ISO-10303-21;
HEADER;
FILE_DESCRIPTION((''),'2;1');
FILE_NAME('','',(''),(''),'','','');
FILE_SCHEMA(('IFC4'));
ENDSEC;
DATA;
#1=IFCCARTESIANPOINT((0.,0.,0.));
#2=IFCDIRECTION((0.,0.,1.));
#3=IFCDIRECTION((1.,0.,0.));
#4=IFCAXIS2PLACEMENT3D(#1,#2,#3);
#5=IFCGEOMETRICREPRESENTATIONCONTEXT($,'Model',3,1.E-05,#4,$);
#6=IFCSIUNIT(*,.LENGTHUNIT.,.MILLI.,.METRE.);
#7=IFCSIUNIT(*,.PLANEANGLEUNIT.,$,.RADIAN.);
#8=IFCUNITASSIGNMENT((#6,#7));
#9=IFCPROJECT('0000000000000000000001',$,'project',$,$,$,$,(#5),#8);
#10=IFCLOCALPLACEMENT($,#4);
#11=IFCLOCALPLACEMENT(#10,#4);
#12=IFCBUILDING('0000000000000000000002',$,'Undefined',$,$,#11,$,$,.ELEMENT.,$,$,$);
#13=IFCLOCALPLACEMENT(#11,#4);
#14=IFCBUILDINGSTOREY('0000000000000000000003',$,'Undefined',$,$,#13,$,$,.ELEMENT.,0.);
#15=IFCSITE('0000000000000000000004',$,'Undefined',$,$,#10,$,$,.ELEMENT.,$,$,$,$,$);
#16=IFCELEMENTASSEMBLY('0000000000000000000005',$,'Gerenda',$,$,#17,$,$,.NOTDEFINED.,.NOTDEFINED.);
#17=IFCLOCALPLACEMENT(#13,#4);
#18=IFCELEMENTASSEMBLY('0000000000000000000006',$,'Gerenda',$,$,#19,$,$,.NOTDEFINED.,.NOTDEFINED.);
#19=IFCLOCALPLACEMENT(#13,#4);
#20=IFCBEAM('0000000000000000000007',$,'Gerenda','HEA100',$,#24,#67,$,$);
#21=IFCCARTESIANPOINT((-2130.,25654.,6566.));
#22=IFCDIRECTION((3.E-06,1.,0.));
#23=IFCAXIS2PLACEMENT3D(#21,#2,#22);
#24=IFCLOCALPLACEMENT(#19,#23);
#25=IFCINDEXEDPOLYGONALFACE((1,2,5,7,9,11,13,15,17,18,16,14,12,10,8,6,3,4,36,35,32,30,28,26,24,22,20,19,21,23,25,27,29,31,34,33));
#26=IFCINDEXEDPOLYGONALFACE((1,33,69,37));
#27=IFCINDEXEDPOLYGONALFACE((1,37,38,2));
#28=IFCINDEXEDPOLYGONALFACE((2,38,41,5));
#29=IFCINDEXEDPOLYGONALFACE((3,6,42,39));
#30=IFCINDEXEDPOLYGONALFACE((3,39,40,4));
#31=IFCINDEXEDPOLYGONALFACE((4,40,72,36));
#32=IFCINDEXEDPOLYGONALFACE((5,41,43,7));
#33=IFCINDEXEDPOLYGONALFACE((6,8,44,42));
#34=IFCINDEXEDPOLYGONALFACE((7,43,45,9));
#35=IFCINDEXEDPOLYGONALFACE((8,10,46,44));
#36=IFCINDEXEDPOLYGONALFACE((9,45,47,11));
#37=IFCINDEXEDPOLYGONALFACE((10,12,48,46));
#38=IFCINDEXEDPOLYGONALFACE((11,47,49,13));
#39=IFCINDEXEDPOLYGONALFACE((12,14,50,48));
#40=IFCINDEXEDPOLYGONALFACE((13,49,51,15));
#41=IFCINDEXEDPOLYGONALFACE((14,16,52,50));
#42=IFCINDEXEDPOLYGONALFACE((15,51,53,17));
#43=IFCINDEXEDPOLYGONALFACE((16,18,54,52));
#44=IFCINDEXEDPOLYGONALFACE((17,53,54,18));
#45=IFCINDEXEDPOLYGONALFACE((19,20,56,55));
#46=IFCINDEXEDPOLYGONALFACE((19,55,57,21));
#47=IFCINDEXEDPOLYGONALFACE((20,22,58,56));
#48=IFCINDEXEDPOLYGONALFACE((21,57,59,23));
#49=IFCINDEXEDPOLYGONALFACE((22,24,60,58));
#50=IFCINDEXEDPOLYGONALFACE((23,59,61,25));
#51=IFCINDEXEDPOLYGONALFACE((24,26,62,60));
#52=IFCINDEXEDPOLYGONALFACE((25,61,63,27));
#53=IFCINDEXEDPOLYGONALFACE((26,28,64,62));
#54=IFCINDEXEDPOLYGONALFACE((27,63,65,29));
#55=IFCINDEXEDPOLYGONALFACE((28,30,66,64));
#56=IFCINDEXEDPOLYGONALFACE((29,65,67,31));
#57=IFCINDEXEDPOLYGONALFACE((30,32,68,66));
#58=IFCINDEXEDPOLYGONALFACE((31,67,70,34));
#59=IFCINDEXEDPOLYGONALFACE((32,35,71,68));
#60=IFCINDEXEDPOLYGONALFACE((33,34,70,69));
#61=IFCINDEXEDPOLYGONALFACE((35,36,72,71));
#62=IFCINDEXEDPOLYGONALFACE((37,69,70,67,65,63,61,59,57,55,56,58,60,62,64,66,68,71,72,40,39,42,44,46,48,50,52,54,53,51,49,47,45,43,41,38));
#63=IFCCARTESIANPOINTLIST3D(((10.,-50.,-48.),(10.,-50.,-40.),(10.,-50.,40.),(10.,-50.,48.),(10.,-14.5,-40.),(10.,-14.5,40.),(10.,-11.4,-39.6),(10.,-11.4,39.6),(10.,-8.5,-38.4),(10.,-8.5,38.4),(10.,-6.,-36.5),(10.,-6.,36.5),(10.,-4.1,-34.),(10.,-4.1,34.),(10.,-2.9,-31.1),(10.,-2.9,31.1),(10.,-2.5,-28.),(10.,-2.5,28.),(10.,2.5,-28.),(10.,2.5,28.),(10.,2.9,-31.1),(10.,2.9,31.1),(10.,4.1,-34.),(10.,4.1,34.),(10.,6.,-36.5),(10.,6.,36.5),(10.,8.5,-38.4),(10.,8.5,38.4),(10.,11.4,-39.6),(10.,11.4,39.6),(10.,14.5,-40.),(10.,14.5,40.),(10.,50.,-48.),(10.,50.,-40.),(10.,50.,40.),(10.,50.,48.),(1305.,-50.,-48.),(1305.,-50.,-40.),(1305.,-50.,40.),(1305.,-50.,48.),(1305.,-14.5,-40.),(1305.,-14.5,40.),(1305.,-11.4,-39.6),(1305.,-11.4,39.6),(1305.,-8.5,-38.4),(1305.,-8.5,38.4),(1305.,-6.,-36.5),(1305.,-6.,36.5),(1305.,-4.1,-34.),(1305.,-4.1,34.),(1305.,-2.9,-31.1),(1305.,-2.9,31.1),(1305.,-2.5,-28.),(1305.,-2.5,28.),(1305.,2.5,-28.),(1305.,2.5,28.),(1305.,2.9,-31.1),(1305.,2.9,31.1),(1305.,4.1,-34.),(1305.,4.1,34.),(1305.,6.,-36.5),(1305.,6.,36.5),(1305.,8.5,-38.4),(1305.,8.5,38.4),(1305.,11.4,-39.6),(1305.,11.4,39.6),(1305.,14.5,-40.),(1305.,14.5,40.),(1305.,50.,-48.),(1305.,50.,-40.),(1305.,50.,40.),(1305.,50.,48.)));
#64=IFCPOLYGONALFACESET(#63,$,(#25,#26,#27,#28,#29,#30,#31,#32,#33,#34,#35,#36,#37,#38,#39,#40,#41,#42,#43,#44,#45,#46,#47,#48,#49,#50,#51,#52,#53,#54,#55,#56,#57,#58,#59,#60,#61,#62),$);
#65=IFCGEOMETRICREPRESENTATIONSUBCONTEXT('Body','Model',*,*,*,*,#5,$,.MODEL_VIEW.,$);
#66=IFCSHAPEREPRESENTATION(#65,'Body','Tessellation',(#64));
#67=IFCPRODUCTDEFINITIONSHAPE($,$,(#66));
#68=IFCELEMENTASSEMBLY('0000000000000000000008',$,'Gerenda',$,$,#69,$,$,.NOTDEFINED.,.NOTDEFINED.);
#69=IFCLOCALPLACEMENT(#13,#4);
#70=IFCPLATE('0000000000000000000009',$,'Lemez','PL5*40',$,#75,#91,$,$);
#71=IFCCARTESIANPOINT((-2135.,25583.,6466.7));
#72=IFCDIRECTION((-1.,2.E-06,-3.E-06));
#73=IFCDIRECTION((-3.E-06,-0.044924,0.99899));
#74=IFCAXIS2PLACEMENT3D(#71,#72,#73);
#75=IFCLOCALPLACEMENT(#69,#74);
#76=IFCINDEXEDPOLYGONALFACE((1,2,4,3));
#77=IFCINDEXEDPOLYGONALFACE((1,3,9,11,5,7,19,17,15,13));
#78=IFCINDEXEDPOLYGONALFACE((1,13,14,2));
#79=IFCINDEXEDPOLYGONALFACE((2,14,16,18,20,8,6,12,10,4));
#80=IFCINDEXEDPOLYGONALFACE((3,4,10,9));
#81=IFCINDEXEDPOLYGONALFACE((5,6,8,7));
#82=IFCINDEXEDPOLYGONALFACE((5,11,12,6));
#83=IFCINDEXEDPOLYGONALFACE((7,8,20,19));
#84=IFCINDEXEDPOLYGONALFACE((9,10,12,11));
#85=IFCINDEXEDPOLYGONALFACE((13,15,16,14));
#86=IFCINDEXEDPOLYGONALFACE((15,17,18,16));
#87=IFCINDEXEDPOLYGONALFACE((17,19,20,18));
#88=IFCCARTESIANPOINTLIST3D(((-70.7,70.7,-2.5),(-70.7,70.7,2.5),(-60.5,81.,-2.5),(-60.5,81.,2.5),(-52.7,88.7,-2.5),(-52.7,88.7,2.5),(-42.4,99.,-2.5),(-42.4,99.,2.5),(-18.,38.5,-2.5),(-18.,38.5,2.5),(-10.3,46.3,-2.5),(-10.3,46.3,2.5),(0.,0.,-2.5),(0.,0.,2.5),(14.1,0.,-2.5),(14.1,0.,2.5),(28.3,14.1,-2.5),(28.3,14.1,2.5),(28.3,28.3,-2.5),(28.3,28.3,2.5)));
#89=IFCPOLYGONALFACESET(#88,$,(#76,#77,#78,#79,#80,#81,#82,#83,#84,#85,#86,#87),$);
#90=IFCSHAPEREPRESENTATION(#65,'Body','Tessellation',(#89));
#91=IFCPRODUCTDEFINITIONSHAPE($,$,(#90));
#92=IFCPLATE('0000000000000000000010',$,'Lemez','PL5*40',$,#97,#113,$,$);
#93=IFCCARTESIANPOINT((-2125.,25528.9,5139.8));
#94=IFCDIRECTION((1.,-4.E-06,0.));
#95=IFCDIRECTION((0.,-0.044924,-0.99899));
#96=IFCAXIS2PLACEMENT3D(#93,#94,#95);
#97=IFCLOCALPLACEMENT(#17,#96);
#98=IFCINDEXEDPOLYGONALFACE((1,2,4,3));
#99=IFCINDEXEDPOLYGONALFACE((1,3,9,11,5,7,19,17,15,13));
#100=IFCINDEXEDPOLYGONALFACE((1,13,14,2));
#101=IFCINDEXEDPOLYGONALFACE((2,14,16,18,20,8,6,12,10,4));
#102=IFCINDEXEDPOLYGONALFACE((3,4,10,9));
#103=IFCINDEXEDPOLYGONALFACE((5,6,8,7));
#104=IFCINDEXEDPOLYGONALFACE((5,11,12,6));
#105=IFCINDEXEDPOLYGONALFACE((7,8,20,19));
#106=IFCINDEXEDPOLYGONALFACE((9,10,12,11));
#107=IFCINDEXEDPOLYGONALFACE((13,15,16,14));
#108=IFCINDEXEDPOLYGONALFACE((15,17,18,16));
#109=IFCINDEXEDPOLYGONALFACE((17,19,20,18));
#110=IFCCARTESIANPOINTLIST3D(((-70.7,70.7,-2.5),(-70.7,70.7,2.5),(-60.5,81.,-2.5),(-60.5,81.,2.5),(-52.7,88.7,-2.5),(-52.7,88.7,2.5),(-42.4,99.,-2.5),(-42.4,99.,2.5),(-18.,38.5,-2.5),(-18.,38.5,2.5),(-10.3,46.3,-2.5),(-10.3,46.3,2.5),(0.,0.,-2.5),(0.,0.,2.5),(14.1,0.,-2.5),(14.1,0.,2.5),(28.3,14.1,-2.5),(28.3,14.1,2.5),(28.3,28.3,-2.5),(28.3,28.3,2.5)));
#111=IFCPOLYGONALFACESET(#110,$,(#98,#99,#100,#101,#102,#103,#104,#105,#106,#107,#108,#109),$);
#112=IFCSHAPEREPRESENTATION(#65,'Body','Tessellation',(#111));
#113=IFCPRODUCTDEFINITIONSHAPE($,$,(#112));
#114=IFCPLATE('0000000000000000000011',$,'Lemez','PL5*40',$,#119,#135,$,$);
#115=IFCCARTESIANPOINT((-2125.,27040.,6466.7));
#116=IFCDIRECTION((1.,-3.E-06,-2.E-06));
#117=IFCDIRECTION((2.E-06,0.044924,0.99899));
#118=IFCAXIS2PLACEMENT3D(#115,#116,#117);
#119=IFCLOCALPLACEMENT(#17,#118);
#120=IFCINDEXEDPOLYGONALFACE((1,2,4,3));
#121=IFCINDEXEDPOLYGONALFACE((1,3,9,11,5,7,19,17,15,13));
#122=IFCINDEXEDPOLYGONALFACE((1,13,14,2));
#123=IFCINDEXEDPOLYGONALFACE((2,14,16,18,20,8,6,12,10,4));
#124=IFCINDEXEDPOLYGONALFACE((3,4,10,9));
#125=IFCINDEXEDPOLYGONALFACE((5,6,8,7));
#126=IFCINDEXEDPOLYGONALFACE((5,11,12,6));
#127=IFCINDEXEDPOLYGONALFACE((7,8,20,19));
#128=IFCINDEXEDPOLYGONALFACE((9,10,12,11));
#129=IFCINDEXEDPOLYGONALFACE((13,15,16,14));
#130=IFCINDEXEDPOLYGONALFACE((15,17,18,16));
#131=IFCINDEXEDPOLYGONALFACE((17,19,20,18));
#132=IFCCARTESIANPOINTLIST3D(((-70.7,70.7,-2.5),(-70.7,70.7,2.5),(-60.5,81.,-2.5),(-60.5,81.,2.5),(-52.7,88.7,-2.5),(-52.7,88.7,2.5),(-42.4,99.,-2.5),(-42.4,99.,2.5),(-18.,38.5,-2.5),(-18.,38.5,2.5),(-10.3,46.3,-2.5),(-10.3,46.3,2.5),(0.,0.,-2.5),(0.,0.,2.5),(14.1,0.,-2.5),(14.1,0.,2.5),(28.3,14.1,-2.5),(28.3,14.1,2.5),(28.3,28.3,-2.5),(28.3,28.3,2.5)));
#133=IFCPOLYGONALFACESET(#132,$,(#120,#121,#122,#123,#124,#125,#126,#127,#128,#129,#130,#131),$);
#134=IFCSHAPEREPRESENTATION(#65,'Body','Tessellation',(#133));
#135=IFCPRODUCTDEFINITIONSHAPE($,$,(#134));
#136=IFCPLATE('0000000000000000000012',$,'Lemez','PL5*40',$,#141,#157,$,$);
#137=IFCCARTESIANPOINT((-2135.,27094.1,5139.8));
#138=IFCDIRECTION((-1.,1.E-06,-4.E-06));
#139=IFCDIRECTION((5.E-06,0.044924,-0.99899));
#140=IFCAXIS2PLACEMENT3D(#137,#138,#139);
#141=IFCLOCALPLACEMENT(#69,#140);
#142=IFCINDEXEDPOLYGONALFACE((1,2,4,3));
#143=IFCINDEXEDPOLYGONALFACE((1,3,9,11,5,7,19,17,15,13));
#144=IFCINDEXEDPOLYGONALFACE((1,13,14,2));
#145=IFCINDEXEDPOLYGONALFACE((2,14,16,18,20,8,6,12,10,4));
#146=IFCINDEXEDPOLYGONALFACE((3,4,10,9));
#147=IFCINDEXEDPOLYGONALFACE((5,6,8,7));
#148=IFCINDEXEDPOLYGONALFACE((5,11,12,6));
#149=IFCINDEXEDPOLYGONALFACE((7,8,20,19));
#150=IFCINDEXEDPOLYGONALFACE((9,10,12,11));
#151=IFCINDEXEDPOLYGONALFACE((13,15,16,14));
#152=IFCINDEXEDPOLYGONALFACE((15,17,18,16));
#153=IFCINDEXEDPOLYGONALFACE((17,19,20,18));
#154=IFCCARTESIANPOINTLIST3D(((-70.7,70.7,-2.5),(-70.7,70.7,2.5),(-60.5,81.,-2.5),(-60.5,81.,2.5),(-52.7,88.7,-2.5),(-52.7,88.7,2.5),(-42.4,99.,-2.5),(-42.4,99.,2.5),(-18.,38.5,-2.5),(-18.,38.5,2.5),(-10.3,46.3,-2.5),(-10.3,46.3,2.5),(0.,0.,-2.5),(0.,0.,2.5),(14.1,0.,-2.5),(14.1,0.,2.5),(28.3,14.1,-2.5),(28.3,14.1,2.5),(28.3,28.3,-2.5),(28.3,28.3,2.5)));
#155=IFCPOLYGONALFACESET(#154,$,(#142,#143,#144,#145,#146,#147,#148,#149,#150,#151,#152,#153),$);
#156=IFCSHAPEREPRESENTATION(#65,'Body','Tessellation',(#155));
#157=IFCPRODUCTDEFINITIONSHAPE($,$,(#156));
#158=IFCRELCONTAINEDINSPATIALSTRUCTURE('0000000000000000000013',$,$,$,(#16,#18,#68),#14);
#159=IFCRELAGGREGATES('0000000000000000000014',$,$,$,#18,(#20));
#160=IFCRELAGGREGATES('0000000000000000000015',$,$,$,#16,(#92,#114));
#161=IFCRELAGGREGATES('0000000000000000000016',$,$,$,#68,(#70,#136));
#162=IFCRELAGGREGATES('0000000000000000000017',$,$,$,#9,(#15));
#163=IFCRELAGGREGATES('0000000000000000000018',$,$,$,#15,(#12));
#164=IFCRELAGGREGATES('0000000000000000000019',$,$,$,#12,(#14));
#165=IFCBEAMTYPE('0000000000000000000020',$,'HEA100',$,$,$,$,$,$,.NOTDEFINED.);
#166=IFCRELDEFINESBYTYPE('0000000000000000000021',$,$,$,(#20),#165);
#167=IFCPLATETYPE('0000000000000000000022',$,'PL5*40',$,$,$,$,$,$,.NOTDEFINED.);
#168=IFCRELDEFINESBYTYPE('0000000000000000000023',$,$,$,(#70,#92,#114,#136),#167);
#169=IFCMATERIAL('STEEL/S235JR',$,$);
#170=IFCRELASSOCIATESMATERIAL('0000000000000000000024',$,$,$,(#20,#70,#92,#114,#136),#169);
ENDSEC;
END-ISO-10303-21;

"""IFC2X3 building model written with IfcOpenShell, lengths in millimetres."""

from ifc_helpers import new_model, si_unit, frame, origin_with_axes, origin_2d_with_axis, place, context, subcontext, project, spatial, polyline, i_section, outline, extrude, clip, halfspace, material, type_object, element, aggregate, save


model = new_model("IFC2X3")

# Units and contexts
model_context = context("Model", 3, precision=1e-05, world=origin_with_axes())
body_context = subcontext(model_context, "Body", "Model", "MODEL_VIEW")
ifc_project = project(units=[si_unit("LENGTHUNIT", "METRE", prefix="MILLI"), si_unit("PLANEANGLEUNIT", "RADIAN")], contexts=[model_context])

# Site, building, storey
site_placement = place(None, origin_with_axes())
site = spatial("IfcSite", under=ifc_project, at=site_placement, Name="Undefined", CompositionType="ELEMENT")
building_placement = place(site_placement, origin_with_axes())
building = spatial("IfcBuilding", under=site, at=building_placement, Name="Undefined", CompositionType="ELEMENT")
storey_placement = place(building_placement, origin_with_axes())
storey = spatial("IfcBuildingStorey", under=building, at=storey_placement, Name="Undefined", CompositionType="ELEMENT", Elevation=0.0)

# Shared definitions
ifc_material_1 = material(Name="STEEL/S235JR")

# Element assemblies, beam
assembly_1_placement = place(storey_placement, origin_with_axes())
assembly_1 = element("IfcElementAssembly", 1, at=assembly_1_placement, inside=storey, Name="Gerenda", AssemblyPlace="NOTDEFINED", PredefinedType="NOTDEFINED")
assembly_2_placement = place(storey_placement, origin_with_axes())
assembly_2 = element("IfcElementAssembly", 2, at=assembly_2_placement, inside=storey, Name="Gerenda", AssemblyPlace="NOTDEFINED", PredefinedType="NOTDEFINED")
beam_type_1 = type_object("IfcBeamType", Name="HEA100", PredefinedType="NOTDEFINED")
beam_1_placement = place(assembly_2_placement, frame((-2130.0, 25654.0, 6566.0), z_axis=(0.0, 0.0, 1.0), x_axis=(0.000003, 1.0, 0.0)))
beam_1 = element("IfcBeam", 3, at=beam_1_placement, type_object=beam_type_1, material=ifc_material_1, Name="Gerenda", Description="HEA100", context=body_context, shape_type="Clipping", body=[
    clip(clip(extrude(i_section(OverallWidth=100.0, OverallDepth=96.0, WebThickness=5.0, FlangeThickness=8.0, FilletRadius=12.0, at=origin_2d_with_axis()), frame((1315.0, 0.0, 0.0), z_axis=(-1.0, 0.0, 0.0), x_axis=(0.0, -1.0, 0.0)), (0.0, 0.0, 1.0), 1315.0), halfspace(frame((1305.0, 0.0, -48.0), z_axis=(-1.0, 0.0, 0.0), x_axis=(0.0, 1.0, 0.0)), True)), halfspace(frame((10.0, 0.0, -48.0), z_axis=(1.0, 0.0, 0.0), x_axis=(0.0, -1.0, 0.0)), True)),
])

# Element assembly, plate
assembly_3_placement = place(storey_placement, origin_with_axes())
assembly_3 = element("IfcElementAssembly", 4, at=assembly_3_placement, inside=storey, Name="Gerenda", AssemblyPlace="NOTDEFINED", PredefinedType="NOTDEFINED")
plate_type_1 = type_object("IfcPlateType", Name="PL5*40", PredefinedType="NOTDEFINED")
plate_1_placement = place(assembly_3_placement, frame((-2135.0, 25583.0, 6466.7), z_axis=(-1.0, 0.000002, -0.000003), x_axis=(-0.000003, -0.044924, 0.99899)))
plate_1 = element("IfcPlate", 5, at=plate_1_placement, type_object=plate_type_1, material=ifc_material_1, Name="Lemez", Description="PL5*40", context=body_context, shape_type="SweptSolid", body=[
    extrude(outline(polyline([(0.0, 0.0), (14.1, 0.0), (28.3, 14.1), (28.3, 28.3), (-42.4, 99.0), (-52.7, 88.7), (-10.3, 46.3), (-18.0, 38.5), (-60.5, 81.0), (-70.7, 70.7), (0.0, 0.0)])), frame((0.0, 0.0, -2.5), z_axis=(0.0, 0.0, 1.0), x_axis=(1.0, 0.0, 0.0)), (0.0, 0.0, 1.0), 5.0),
])

# Plates
plate_2_placement = place(assembly_1_placement, frame((-2125.0, 25528.9, 5139.8), z_axis=(1.0, -0.000004, 0.0), x_axis=(0.0, -0.044924, -0.99899)))
plate_2 = element("IfcPlate", 6, at=plate_2_placement, type_object=plate_type_1, material=ifc_material_1, Name="Lemez", Description="PL5*40", context=body_context, shape_type="SweptSolid", body=[
    extrude(outline(polyline([(0.0, 0.0), (14.1, 0.0), (28.3, 14.1), (28.3, 28.3), (-42.4, 99.0), (-52.7, 88.7), (-10.3, 46.3), (-18.0, 38.5), (-60.5, 81.0), (-70.7, 70.7), (0.0, 0.0)])), frame((0.0, 0.0, -2.5), z_axis=(0.0, 0.0, 1.0), x_axis=(1.0, 0.0, 0.0)), (0.0, 0.0, 1.0), 5.0),
])
plate_3_placement = place(assembly_1_placement, frame((-2125.0, 27040.0, 6466.7), z_axis=(1.0, -0.000003, -0.000002), x_axis=(0.000002, 0.044924, 0.99899)))
plate_3 = element("IfcPlate", 7, at=plate_3_placement, type_object=plate_type_1, material=ifc_material_1, Name="Lemez", Description="PL5*40", context=body_context, shape_type="SweptSolid", body=[
    extrude(outline(polyline([(0.0, 0.0), (14.1, 0.0), (28.3, 14.1), (28.3, 28.3), (-42.4, 99.0), (-52.7, 88.7), (-10.3, 46.3), (-18.0, 38.5), (-60.5, 81.0), (-70.7, 70.7), (0.0, 0.0)])), frame((0.0, 0.0, -2.5), z_axis=(0.0, 0.0, 1.0), x_axis=(1.0, 0.0, 0.0)), (0.0, 0.0, 1.0), 5.0),
])
plate_4_placement = place(assembly_3_placement, frame((-2135.0, 27094.1, 5139.8), z_axis=(-1.0, 0.000001, -0.000004), x_axis=(0.000005, 0.044924, -0.99899)))
plate_4 = element("IfcPlate", 8, at=plate_4_placement, type_object=plate_type_1, material=ifc_material_1, Name="Lemez", Description="PL5*40", context=body_context, shape_type="SweptSolid", body=[
    extrude(outline(polyline([(0.0, 0.0), (14.1, 0.0), (28.3, 14.1), (28.3, 28.3), (-42.4, 99.0), (-52.7, 88.7), (-10.3, 46.3), (-18.0, 38.5), (-60.5, 81.0), (-70.7, 70.7), (0.0, 0.0)])), frame((0.0, 0.0, -2.5), z_axis=(0.0, 0.0, 1.0), x_axis=(1.0, 0.0, 0.0)), (0.0, 0.0, 1.0), 5.0),
])
aggregate(assembly_2, [beam_1])

aggregate(assembly_1, [plate_2, plate_3])
aggregate(assembly_3, [plate_1, plate_4])

save(model, "model.ifc")
